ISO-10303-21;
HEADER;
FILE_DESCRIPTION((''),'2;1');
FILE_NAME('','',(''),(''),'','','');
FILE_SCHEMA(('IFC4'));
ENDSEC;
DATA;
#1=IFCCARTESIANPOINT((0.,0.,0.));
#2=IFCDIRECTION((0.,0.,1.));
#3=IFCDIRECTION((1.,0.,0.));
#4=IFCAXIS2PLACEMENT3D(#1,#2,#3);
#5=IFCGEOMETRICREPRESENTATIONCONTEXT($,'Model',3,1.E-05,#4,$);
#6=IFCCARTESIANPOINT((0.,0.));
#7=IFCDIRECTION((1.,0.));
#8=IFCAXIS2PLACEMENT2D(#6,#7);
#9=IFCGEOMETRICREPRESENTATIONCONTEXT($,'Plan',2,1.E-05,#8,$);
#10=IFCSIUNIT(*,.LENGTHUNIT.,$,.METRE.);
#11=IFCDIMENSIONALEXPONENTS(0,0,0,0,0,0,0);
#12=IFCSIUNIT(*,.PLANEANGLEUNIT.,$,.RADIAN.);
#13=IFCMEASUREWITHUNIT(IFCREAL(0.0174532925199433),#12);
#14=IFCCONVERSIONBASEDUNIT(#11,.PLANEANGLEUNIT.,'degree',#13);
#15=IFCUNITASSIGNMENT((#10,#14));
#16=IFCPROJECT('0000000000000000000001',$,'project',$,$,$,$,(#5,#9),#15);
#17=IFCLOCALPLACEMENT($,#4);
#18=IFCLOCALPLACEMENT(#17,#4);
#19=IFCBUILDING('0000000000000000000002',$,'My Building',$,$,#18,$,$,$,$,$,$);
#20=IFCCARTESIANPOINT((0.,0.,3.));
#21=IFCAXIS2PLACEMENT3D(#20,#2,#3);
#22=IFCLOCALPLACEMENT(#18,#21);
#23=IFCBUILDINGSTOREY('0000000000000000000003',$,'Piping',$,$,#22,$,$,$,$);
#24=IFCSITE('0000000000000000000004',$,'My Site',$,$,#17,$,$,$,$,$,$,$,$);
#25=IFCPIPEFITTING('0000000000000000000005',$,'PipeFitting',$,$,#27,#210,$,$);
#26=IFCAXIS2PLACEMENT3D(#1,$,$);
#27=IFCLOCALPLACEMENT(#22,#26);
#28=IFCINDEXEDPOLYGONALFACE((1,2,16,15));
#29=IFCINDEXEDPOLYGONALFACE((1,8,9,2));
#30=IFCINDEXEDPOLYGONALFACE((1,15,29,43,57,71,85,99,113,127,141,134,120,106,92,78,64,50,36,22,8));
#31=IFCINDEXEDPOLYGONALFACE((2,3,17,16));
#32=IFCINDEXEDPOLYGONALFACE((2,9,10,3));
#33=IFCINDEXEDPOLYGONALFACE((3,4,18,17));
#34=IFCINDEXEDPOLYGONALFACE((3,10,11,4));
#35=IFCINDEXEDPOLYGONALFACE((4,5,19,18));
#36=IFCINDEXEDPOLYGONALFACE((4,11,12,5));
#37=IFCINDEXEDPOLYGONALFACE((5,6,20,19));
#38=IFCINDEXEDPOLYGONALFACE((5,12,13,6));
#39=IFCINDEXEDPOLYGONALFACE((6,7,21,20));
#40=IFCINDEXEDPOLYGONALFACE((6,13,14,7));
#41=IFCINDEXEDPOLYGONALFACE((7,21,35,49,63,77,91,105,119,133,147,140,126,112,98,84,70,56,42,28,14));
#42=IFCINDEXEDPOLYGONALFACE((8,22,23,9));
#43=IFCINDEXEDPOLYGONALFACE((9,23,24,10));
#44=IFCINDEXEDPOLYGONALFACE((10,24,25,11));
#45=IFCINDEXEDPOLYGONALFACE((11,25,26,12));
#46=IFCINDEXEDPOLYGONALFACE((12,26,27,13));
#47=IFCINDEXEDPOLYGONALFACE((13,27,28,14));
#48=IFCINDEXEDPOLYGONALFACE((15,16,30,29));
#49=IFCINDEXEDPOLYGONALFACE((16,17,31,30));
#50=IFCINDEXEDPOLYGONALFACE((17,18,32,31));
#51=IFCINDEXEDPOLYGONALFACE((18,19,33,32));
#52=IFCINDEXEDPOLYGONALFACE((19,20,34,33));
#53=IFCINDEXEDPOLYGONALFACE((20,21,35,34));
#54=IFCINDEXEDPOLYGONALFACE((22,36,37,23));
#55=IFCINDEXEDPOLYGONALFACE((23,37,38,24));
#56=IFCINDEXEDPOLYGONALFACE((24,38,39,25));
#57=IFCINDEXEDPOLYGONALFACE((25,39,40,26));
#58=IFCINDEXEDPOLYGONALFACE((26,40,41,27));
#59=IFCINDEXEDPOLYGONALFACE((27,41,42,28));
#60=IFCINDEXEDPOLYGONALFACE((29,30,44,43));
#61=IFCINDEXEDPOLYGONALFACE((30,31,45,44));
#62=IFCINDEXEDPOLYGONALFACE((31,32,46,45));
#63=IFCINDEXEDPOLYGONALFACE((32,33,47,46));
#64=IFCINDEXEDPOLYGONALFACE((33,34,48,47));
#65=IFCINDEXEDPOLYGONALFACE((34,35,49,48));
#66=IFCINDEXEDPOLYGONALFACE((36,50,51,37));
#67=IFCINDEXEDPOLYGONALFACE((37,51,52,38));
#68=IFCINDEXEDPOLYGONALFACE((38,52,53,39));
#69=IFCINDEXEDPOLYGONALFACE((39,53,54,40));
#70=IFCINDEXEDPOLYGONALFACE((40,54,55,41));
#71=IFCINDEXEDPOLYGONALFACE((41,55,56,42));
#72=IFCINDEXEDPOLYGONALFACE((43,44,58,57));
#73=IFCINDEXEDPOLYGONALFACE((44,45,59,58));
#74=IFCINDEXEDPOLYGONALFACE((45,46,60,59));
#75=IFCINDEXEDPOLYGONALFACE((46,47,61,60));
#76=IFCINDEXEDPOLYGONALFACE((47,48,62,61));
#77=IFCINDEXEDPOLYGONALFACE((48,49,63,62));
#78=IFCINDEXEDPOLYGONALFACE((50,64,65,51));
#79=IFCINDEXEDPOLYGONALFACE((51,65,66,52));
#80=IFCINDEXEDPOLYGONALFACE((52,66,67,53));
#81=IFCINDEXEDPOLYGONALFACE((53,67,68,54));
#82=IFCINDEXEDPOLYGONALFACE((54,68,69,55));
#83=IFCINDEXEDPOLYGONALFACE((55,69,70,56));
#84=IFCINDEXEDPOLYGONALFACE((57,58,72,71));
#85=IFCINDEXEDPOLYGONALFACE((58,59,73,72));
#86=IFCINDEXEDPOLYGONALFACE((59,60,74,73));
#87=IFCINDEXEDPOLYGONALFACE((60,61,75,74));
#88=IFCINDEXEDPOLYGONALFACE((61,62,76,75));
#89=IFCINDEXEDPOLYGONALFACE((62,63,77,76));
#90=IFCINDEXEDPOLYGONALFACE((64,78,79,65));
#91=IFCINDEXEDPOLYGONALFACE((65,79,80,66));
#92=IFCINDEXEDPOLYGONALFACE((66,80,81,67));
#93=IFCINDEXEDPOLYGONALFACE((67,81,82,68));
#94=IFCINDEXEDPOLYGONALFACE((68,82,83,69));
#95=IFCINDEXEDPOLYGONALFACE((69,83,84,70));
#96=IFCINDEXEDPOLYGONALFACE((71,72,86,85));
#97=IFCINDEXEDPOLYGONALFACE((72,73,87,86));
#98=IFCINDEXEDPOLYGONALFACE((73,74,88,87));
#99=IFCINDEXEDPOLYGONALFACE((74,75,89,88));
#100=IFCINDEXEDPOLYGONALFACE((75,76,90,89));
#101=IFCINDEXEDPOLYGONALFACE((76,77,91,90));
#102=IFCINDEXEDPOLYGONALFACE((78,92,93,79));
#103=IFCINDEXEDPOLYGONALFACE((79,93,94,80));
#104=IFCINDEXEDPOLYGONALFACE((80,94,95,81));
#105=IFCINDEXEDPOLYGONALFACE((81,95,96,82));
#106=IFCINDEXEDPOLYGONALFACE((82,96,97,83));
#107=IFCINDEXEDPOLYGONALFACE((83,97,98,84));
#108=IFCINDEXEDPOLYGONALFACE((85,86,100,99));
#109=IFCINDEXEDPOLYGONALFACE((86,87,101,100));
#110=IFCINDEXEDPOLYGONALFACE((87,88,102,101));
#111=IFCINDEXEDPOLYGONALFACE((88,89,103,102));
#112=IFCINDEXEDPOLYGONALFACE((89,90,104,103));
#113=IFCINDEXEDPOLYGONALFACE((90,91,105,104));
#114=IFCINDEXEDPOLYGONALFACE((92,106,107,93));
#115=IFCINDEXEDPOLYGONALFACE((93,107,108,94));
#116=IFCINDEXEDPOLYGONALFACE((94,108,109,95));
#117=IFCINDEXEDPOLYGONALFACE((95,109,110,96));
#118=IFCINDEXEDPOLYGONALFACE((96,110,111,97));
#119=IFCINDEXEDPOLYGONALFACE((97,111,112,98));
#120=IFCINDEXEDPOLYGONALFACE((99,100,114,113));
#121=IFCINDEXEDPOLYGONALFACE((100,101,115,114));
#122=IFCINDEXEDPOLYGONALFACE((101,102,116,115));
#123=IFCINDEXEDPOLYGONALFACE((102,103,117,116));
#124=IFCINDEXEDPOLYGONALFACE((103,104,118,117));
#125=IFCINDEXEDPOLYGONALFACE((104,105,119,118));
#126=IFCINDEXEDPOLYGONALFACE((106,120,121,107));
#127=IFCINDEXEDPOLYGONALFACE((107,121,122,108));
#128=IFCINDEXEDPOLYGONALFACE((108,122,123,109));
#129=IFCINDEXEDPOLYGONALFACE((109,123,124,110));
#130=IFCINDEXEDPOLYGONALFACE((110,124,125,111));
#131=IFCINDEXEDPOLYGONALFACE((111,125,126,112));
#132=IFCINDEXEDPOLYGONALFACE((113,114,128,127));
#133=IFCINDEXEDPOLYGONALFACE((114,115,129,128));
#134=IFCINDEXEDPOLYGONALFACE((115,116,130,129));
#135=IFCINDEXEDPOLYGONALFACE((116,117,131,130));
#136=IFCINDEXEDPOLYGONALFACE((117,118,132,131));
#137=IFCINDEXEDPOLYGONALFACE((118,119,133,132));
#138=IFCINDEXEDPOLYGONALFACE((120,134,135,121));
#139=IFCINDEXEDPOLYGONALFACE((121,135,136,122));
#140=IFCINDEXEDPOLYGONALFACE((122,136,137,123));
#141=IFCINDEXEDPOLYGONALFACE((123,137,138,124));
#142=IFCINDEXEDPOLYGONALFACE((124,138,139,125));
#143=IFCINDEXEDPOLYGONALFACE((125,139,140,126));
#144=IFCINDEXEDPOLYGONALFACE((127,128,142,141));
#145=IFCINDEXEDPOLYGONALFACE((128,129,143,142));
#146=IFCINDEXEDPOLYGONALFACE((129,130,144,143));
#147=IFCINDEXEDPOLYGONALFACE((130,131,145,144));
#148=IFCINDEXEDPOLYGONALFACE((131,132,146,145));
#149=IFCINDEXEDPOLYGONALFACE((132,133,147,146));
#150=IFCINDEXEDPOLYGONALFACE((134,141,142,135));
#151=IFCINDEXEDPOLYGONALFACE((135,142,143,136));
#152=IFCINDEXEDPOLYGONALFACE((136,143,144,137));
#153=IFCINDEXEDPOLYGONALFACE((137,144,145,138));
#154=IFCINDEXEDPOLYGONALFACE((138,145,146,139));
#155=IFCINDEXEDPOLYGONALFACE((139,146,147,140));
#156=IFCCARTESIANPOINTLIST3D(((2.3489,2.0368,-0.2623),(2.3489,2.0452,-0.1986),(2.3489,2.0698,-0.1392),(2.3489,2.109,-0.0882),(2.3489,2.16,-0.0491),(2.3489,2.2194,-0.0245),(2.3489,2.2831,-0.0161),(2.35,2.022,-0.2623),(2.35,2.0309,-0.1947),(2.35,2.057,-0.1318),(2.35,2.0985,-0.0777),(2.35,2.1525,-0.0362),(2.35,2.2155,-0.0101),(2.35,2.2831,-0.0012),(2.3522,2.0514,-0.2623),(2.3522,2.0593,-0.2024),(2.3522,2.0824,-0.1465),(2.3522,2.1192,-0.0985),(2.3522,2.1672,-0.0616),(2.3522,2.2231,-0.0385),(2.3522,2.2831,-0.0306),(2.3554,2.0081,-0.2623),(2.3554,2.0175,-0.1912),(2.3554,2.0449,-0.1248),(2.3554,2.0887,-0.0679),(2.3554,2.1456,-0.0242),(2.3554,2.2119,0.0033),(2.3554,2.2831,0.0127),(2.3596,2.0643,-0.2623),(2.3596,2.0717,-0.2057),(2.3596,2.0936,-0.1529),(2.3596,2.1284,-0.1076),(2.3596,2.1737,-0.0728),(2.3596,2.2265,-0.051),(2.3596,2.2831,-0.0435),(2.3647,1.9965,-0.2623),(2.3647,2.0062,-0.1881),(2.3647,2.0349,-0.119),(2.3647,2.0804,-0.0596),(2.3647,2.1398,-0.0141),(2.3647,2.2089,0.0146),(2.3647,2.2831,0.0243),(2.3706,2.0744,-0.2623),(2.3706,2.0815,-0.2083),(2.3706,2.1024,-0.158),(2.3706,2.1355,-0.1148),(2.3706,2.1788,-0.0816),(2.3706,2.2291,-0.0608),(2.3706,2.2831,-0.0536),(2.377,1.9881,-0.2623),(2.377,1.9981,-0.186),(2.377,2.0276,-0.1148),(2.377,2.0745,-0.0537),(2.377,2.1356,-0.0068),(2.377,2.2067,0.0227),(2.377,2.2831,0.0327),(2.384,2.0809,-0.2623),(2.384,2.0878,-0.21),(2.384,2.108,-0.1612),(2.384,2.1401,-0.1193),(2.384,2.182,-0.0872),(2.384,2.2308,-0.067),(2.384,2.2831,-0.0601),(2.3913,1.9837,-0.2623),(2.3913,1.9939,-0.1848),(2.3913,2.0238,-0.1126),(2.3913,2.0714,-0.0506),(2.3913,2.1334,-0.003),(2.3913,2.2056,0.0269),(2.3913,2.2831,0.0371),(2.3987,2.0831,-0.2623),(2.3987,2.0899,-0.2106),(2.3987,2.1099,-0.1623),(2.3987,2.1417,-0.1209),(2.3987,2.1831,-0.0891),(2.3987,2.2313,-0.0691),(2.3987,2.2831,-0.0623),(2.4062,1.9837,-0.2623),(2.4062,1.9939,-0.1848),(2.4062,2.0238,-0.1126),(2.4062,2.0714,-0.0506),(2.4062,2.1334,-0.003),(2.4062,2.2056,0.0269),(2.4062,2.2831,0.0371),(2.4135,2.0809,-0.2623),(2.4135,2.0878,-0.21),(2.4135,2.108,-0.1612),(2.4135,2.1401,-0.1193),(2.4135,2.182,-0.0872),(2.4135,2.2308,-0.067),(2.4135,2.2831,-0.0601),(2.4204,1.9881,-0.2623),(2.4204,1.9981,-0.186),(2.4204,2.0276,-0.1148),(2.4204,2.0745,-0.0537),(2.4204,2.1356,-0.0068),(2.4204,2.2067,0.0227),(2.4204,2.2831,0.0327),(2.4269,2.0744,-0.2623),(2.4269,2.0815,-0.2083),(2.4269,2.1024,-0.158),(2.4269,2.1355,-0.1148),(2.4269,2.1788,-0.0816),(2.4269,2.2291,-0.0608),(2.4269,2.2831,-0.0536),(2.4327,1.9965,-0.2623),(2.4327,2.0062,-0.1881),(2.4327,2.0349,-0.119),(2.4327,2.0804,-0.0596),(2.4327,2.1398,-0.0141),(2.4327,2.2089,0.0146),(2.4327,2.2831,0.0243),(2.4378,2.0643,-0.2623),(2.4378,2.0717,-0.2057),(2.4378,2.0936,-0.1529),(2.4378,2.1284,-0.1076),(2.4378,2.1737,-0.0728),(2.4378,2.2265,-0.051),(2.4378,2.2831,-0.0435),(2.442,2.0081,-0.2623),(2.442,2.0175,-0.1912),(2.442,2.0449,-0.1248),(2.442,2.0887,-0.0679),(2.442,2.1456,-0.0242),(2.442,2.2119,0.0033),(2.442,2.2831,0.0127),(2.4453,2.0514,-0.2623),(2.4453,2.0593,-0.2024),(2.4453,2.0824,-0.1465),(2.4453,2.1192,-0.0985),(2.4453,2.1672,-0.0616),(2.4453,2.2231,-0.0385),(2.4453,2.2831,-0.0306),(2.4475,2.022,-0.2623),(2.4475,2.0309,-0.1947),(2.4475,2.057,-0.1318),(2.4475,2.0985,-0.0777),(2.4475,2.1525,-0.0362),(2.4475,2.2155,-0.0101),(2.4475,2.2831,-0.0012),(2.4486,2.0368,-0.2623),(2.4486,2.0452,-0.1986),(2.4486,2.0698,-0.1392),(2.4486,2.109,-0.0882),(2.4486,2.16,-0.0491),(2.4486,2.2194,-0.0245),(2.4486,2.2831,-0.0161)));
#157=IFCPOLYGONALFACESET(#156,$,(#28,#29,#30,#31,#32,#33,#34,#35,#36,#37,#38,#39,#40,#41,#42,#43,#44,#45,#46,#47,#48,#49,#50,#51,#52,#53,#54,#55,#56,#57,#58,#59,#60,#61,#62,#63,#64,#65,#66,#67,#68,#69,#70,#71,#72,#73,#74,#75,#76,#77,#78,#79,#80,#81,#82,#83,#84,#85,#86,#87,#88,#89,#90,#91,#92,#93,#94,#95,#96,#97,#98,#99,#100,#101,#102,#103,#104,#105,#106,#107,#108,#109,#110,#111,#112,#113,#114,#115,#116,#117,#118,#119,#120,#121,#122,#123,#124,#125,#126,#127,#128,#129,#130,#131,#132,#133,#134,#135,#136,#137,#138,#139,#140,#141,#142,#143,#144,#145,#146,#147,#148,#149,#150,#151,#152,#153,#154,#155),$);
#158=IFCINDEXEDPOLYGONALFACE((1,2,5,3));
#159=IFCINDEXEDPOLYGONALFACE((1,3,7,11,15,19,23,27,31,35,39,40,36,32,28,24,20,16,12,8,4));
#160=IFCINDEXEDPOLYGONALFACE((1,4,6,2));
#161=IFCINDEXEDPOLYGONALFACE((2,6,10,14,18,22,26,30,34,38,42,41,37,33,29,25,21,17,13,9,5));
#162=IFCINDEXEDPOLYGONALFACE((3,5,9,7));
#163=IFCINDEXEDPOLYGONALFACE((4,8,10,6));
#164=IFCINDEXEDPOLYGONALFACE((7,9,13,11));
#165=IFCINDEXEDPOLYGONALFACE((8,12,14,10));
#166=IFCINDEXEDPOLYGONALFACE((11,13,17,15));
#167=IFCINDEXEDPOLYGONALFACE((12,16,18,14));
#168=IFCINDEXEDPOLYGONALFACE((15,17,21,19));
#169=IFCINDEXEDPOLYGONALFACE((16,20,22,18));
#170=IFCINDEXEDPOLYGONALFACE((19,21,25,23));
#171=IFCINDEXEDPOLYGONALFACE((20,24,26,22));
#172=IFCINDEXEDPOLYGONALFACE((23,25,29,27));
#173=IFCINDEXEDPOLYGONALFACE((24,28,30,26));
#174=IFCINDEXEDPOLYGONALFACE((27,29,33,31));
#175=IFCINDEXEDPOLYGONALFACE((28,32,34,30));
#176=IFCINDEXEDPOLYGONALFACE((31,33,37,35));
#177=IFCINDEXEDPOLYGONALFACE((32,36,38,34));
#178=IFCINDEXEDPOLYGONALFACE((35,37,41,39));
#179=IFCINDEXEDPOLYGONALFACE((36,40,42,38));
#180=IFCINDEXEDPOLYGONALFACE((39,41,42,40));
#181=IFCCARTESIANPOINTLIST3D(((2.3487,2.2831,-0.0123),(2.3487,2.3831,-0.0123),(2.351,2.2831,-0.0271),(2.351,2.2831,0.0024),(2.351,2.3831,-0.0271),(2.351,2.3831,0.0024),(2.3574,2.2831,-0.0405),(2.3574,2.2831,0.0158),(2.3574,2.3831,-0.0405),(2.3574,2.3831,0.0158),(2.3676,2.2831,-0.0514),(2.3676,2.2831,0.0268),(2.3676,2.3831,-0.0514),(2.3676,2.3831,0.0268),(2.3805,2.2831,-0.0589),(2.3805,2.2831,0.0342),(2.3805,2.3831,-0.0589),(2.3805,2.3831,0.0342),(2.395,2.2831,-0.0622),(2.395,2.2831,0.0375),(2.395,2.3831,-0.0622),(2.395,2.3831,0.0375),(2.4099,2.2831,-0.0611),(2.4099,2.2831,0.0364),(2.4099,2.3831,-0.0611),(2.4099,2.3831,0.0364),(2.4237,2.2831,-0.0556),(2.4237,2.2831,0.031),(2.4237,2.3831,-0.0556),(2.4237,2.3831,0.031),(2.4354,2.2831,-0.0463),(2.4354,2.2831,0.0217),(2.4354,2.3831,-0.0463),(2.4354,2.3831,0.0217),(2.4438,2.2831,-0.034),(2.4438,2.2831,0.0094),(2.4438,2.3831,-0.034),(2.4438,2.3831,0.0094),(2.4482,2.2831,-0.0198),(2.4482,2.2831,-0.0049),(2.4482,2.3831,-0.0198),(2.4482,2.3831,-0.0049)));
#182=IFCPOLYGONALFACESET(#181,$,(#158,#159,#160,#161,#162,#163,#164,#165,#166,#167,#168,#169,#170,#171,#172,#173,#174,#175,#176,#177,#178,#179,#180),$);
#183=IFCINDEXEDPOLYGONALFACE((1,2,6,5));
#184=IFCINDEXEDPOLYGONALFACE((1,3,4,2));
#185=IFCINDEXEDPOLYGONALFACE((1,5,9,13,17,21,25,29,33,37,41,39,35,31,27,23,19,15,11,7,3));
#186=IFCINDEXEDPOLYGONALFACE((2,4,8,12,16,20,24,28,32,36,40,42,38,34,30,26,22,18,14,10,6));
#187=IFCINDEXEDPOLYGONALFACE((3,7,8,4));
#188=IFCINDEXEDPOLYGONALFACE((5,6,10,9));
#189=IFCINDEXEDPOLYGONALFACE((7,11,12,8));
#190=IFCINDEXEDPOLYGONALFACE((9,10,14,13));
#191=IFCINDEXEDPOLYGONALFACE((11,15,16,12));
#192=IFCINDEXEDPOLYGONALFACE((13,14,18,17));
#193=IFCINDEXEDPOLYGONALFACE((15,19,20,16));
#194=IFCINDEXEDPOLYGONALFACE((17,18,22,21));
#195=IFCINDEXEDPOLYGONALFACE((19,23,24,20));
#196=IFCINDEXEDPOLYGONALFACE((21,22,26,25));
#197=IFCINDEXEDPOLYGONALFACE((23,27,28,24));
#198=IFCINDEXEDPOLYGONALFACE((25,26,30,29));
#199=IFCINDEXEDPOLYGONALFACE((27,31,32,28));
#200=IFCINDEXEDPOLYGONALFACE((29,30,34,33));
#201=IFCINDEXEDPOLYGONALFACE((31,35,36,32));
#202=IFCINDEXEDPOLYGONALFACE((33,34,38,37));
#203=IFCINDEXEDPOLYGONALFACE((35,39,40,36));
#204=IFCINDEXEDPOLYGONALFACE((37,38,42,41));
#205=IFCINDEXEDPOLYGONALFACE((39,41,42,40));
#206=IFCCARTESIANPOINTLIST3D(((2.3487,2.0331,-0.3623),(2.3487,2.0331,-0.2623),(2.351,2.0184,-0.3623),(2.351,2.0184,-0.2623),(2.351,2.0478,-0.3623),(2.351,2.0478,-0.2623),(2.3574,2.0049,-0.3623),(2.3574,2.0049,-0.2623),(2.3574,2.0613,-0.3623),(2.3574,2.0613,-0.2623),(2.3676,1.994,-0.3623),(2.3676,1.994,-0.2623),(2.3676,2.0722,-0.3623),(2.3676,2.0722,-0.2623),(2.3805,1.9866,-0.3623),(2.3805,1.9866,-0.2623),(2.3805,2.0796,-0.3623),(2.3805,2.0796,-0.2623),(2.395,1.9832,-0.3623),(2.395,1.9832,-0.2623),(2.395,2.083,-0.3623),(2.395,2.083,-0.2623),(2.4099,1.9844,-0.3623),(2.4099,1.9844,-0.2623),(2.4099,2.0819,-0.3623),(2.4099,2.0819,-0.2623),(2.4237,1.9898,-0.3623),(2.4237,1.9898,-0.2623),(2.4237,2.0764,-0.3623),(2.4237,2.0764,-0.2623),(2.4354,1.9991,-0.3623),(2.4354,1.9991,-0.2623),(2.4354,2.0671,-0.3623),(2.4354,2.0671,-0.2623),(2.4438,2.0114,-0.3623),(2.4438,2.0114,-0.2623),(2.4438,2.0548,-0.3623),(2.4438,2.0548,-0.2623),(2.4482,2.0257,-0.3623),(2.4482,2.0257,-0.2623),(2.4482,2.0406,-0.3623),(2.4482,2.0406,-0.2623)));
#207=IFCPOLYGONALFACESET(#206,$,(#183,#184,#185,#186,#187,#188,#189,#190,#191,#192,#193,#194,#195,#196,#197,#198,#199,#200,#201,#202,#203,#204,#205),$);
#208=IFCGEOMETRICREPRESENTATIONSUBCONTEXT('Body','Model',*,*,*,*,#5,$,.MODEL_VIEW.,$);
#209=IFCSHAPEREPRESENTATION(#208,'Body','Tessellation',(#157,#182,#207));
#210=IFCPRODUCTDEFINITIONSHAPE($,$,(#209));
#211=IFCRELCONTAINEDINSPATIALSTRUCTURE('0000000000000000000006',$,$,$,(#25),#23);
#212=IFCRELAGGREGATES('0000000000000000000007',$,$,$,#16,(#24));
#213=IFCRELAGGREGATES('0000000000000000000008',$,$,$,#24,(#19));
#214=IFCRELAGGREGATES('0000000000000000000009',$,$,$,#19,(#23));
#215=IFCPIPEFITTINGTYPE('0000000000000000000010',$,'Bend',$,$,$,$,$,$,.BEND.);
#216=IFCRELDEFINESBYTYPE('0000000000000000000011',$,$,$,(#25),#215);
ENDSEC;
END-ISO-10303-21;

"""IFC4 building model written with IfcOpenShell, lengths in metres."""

from ifc_helpers import new_model, entity, si_unit, converted_unit, frame, origin_with_axes, origin_2d_with_axis, place, context, subcontext, project, spatial, circle, extrude, source, transform, mapped, type_object, type_shapes, element, save


model = new_model("IFC4")

# Units and contexts
model_context = context("Model", 3, precision=1e-05, world=origin_with_axes())
plan_context = context("Plan", 2, precision=1e-05, world=origin_2d_with_axis())
body_context = subcontext(model_context, "Body", "Model", "MODEL_VIEW")
ifc_project = project(units=[si_unit("LENGTHUNIT", "METRE"), converted_unit("PLANEANGLEUNIT", "degree", entity("IfcReal", 0.0174532925199433), si_unit("PLANEANGLEUNIT", "RADIAN"), dimensions=[0, 0, 0, 0, 0, 0, 0])], contexts=[model_context, plan_context])

# Site, building, storey
site_placement = place(None, origin_with_axes())
site = spatial("IfcSite", under=ifc_project, at=site_placement, Name="My Site")
building_placement = place(site_placement, origin_with_axes())
building = spatial("IfcBuilding", under=site, at=building_placement, Name="My Building")
storey_placement = place(building_placement, frame((0.0, 0.0, 3.0), z_axis=(0.0, 0.0, 1.0), x_axis=(1.0, 0.0, 0.0)))
storey = spatial("IfcBuildingStorey", under=building, at=storey_placement, Name="Piping")

# Pipe fitting
pipe_fitting_type = type_object("IfcPipeFittingType", Name="Bend", PredefinedType="BEND")
shared_shape = source(origin_with_axes(), body_context, "Body", "SolidModel", [
    entity("IfcSweptDiskSolid", entity("IfcIndexedPolyCurve", entity("IfcCartesianPointList3D", [[0.0, 0.0, -0.1], [0.0, -0.0732, -0.2768], [0.0, -0.25, -0.35]]), [entity("IfcArcIndex", [1, 2, 3])]), 0.05),
    extrude(circle(Radius=0.05), origin_with_axes(), (0.0, 0.0, -1.0), 0.1),
    extrude(circle(Radius=0.05), frame((0.0, -0.25, -0.35), z_axis=(0.0, -1.0, 0.0), x_axis=(1.0, 0.0, 0.0)), (0.0, 0.0, 1.0), 0.1),
])
type_shapes(pipe_fitting_type, [shared_shape])
for number, where, z_axis, x_axis, name in (
    (1, (2.3987, 2.3831, -0.0123), (0.0, 1.0, 0.0), (-1.0, 0.0, 0.0), "PipeFitting"),
):
    element("IfcPipeFitting", number, at=place(storey_placement, frame(where, z_axis=z_axis, x_axis=x_axis)), inside=storey, type_object=pipe_fitting_type, Name=name, context=body_context, shape_type="MappedRepresentation", body=[
        mapped(shared_shape, transform((0.0, 0.0, 0.0), x_axis=(1.0, 0.0, 0.0), y_axis=(0.0, 1.0, 0.0), z_axis=(0.0, 0.0, 1.0), scale=1.0)),
    ])

save(model, "model.ifc")
